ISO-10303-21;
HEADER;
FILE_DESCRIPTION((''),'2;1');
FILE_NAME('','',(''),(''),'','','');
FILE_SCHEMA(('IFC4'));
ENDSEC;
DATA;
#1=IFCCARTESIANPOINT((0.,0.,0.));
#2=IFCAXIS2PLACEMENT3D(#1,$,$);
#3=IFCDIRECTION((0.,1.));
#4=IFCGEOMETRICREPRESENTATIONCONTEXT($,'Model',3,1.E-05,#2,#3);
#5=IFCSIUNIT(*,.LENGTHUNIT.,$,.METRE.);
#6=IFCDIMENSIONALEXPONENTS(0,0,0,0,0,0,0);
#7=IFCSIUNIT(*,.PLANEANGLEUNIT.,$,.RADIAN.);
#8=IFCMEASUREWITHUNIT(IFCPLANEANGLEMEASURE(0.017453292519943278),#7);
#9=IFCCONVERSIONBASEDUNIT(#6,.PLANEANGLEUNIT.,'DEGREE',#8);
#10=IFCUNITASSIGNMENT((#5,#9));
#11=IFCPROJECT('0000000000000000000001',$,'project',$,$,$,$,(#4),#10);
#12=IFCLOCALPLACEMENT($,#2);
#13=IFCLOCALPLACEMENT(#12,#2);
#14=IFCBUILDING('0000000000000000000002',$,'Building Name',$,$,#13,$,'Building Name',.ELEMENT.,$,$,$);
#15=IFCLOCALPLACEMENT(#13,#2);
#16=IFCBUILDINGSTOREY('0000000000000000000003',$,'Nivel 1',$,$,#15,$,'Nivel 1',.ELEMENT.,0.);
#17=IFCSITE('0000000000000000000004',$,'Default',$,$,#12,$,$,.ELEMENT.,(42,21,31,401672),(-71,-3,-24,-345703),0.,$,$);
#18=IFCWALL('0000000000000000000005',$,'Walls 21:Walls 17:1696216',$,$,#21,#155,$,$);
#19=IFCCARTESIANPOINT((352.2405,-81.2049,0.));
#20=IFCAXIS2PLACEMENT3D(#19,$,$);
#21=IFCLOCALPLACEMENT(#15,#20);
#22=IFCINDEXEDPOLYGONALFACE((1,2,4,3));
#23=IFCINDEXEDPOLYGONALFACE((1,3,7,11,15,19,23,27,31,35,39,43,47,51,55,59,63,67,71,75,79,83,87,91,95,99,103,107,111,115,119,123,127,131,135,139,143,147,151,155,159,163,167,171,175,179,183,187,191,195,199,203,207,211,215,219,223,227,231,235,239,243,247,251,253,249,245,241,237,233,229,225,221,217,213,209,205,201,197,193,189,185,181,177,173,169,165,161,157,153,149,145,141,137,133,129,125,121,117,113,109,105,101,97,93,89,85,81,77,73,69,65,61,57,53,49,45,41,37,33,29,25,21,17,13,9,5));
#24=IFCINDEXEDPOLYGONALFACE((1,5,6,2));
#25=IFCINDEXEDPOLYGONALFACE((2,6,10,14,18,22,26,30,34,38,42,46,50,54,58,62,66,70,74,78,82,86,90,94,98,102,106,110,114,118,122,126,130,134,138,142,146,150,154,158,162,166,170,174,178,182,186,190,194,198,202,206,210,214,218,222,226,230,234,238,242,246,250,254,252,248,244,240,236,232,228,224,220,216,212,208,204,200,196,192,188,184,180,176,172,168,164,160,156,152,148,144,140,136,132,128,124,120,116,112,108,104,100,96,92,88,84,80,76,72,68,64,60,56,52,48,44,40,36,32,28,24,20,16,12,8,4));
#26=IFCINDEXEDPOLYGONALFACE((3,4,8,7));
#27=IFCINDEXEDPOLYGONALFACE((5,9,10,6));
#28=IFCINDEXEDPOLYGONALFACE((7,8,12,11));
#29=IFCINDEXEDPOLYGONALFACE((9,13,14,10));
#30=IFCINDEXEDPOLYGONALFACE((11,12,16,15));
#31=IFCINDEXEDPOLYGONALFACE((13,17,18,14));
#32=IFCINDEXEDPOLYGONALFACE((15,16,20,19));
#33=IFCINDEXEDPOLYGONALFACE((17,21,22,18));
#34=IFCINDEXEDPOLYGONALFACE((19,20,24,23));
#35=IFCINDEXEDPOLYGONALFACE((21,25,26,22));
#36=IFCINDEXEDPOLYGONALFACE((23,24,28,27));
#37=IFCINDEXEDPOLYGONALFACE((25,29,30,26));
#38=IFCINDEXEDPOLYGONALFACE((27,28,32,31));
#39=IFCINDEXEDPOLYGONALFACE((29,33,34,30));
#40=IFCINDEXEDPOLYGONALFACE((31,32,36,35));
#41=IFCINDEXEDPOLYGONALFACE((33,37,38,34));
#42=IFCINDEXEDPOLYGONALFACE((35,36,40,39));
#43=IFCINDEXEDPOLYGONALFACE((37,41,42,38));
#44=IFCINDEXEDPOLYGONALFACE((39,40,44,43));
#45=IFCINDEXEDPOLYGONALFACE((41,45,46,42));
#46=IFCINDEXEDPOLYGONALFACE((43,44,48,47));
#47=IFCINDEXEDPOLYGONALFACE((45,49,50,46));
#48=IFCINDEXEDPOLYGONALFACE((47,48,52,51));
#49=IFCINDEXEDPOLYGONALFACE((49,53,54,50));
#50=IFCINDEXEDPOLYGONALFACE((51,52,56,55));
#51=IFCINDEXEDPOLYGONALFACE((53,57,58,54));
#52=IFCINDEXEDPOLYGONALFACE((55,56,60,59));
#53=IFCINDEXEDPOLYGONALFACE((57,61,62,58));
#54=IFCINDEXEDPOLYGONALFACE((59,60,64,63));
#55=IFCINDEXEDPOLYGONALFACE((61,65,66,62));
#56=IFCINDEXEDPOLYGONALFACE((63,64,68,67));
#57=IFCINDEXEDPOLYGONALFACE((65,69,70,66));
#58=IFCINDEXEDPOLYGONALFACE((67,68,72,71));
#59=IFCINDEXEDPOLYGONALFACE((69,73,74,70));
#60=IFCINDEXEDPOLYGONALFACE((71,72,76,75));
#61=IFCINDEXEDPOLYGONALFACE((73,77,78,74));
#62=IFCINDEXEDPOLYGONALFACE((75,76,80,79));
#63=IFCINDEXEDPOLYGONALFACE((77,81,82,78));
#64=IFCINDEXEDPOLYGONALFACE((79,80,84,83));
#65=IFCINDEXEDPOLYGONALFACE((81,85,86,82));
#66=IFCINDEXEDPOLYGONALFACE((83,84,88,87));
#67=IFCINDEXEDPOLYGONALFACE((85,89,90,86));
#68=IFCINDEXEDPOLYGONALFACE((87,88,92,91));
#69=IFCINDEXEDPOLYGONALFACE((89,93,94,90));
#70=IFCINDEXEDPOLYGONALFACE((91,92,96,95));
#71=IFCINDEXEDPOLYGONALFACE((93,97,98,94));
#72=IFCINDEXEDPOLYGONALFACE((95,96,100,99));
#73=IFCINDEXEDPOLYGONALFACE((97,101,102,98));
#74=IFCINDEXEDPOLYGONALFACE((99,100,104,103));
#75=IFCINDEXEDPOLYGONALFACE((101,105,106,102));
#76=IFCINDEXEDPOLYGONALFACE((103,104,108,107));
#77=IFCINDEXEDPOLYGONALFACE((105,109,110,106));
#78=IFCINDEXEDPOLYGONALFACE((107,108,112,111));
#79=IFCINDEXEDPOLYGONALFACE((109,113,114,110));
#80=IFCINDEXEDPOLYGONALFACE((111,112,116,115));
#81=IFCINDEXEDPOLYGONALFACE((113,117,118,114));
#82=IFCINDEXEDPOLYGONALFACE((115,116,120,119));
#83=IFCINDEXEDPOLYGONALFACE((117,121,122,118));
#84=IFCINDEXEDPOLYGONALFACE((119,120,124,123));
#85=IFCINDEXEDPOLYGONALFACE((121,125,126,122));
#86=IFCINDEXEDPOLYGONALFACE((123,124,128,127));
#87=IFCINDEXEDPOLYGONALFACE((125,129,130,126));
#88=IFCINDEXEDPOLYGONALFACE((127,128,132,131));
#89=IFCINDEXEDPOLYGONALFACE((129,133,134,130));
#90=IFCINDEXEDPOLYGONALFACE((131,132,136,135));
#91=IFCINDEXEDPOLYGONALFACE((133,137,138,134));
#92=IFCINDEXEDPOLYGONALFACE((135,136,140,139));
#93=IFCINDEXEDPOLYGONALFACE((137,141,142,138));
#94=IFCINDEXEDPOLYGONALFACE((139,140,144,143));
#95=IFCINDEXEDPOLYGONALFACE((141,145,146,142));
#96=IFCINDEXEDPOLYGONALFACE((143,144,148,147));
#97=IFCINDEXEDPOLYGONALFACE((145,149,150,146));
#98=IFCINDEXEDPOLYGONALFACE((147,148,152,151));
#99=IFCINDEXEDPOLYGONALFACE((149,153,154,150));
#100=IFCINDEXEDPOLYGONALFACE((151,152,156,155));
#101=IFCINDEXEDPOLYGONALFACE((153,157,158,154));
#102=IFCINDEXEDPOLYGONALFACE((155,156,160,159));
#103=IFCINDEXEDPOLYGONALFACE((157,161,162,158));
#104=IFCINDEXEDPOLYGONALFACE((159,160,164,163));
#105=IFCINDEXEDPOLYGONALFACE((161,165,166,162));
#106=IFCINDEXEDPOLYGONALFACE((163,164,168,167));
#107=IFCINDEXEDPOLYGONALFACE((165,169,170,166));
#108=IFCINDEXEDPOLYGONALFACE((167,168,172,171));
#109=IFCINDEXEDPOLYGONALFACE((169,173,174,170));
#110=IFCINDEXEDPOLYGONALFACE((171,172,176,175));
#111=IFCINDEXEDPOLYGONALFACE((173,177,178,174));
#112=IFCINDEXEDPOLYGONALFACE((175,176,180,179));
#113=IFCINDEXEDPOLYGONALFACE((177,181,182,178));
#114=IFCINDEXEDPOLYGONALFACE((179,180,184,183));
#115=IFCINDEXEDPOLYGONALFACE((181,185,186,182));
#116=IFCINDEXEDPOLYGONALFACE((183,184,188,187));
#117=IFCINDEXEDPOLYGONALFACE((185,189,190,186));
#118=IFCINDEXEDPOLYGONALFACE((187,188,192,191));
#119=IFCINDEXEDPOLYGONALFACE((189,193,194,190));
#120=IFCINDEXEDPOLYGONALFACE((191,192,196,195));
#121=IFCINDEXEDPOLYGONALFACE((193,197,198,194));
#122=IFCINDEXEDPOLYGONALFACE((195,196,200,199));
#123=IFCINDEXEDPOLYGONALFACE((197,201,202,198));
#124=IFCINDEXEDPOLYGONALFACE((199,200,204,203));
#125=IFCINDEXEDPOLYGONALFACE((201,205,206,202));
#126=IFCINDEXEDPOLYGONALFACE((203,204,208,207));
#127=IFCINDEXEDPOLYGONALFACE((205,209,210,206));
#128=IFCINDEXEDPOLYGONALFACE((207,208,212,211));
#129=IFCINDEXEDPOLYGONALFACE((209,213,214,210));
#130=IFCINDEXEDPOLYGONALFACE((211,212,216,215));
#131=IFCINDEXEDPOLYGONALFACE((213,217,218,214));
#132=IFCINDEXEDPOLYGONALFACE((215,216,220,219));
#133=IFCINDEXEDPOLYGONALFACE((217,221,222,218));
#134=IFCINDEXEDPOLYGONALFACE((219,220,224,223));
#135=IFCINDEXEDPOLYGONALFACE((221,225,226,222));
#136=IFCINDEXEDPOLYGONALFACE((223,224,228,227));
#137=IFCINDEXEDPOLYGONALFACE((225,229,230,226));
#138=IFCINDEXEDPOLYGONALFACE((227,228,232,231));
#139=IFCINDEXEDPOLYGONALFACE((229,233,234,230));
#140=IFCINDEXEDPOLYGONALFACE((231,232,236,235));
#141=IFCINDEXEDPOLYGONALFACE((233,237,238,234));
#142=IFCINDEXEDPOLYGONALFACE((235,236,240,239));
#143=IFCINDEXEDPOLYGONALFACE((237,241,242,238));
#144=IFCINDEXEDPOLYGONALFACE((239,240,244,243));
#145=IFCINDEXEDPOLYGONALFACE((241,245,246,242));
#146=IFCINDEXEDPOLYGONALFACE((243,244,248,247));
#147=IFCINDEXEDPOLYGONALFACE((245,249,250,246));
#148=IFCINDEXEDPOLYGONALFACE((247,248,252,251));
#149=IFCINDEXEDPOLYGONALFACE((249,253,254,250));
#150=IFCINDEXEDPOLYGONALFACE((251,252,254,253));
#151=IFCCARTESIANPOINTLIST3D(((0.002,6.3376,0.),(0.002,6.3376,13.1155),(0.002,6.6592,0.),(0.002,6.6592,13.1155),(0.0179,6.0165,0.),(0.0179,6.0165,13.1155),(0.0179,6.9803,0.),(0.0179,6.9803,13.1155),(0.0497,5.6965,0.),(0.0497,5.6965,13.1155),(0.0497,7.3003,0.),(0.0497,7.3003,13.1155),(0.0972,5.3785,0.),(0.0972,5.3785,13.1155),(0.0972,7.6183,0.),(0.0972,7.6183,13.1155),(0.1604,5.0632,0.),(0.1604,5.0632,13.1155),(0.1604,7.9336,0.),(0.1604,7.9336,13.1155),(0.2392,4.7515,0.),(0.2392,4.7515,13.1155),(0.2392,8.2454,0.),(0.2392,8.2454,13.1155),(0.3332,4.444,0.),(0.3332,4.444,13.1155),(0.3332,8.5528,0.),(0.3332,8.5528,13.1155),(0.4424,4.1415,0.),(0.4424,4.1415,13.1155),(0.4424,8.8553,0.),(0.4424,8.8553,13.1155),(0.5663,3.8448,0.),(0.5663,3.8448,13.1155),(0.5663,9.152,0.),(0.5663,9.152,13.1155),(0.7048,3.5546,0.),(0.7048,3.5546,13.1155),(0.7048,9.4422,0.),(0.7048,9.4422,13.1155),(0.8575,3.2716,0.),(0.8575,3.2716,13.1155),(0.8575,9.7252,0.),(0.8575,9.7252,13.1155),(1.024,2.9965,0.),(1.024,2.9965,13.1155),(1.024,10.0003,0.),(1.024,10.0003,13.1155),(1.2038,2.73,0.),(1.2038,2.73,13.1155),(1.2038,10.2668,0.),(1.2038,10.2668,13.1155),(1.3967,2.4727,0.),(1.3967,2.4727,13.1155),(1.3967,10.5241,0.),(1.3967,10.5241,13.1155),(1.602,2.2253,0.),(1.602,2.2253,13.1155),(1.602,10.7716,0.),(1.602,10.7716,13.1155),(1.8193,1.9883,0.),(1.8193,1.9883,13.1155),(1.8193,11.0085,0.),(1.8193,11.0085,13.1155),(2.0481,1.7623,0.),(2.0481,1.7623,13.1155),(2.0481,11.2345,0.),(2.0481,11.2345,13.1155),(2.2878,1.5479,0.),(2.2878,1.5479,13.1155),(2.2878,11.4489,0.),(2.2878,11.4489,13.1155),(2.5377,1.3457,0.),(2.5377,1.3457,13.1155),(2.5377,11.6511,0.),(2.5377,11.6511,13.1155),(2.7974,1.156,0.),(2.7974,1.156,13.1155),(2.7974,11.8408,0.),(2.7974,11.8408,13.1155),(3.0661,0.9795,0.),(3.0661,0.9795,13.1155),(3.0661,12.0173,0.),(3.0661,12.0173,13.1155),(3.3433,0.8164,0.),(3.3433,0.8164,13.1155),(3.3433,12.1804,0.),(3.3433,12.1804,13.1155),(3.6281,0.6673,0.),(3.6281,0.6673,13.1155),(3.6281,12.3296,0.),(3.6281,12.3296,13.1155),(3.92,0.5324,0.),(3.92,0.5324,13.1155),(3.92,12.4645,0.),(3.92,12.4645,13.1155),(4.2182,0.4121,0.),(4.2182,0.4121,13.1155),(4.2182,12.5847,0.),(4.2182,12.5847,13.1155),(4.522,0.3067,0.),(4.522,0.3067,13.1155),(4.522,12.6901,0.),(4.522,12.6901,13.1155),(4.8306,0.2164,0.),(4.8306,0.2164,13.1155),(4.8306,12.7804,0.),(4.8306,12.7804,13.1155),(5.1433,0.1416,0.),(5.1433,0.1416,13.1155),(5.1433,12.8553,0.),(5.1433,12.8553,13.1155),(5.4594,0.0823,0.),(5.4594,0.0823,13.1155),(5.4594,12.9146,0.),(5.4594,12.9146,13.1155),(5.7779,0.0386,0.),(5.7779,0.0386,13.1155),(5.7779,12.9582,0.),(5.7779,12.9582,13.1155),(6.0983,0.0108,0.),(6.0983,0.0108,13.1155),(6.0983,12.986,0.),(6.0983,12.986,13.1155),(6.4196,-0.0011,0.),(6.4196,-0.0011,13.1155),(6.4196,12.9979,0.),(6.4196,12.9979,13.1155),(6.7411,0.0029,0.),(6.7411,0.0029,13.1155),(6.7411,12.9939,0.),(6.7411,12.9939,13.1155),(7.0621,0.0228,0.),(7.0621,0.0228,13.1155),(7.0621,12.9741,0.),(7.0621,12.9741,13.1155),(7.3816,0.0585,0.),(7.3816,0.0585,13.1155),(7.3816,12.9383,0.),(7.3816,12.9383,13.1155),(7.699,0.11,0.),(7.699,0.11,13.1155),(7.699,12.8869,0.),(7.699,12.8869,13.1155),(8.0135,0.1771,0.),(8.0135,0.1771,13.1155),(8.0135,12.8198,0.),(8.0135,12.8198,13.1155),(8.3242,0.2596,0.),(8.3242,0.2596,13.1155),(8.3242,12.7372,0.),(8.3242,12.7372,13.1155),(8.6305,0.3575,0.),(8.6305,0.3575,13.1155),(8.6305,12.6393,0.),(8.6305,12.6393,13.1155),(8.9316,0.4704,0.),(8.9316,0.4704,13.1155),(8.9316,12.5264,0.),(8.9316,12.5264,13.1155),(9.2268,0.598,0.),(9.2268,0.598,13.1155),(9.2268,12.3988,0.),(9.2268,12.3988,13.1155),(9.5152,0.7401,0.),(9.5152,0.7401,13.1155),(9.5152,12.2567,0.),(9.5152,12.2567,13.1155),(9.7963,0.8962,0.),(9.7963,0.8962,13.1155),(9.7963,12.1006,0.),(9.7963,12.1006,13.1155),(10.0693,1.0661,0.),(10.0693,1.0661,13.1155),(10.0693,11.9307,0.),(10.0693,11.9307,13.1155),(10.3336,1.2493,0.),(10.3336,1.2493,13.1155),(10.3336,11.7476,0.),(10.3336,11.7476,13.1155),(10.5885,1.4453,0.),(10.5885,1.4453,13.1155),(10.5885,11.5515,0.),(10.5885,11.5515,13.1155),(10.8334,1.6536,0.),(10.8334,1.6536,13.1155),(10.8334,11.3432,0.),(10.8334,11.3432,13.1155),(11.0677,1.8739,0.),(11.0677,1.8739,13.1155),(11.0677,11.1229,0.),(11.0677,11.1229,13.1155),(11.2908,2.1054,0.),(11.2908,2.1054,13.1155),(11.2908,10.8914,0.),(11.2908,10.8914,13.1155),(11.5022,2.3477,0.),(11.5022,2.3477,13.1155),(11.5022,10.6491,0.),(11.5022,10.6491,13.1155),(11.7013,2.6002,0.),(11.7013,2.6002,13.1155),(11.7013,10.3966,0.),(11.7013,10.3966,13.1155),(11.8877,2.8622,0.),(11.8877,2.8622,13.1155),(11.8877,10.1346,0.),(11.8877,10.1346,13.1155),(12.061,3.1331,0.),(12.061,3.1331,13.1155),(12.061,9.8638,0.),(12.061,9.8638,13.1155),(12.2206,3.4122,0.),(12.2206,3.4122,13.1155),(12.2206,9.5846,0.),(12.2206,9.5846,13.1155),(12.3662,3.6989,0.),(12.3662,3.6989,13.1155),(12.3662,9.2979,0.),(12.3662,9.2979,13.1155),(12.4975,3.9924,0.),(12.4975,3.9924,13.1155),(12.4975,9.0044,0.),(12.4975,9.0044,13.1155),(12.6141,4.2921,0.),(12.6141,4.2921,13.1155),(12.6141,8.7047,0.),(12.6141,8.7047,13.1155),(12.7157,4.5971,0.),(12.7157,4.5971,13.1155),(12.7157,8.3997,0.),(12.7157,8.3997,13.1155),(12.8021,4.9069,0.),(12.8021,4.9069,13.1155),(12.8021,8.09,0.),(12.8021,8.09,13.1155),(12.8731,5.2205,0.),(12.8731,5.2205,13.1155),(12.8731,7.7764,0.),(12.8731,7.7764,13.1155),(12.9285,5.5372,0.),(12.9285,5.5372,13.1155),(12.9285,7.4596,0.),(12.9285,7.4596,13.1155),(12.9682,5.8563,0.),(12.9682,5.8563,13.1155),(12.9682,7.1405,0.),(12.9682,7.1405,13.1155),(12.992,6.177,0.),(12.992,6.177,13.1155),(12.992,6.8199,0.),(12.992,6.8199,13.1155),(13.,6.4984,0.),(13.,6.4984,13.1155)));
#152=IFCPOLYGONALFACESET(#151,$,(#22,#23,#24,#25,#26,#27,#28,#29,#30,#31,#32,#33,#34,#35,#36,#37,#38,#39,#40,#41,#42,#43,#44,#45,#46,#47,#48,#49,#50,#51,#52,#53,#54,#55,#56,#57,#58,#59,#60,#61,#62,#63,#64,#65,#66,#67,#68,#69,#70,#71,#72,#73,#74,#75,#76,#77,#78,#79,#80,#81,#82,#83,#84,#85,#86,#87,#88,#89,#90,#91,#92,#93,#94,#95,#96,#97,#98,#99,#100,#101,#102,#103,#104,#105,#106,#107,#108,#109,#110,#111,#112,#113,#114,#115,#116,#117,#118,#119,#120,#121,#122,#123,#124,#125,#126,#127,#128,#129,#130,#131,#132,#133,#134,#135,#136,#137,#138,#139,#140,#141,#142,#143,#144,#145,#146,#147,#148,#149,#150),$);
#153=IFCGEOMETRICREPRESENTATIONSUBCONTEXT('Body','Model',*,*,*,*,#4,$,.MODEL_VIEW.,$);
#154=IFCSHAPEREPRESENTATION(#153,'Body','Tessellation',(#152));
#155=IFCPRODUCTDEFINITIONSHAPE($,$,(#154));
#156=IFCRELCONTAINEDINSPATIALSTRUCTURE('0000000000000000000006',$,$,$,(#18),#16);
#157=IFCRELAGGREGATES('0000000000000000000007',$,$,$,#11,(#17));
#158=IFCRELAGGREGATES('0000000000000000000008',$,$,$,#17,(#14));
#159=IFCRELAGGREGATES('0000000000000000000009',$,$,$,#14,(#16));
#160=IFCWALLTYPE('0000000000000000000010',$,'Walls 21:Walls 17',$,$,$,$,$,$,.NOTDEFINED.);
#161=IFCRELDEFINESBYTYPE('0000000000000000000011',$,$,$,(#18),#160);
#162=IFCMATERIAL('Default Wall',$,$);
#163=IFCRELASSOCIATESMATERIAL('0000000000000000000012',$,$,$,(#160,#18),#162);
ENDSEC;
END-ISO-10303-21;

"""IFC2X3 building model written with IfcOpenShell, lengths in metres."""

from ifc_helpers import new_model, entity, si_unit, converted_unit, direction, frame, frame_2d, origin, place, context, subcontext, project, spatial, circle, extrude, material, type_object, element, save


model = new_model("IFC2X3")

# Units and contexts
model_context = context("Model", 3, precision=1e-05, world=origin(), true_north=direction((0.0, 1.0)))
body_context = subcontext(model_context, "Body", "Model", "MODEL_VIEW")
ifc_project = project(units=[si_unit("LENGTHUNIT", "METRE"), converted_unit("PLANEANGLEUNIT", "DEGREE", entity("IfcPlaneAngleMeasure", 0.017453292519943278), si_unit("PLANEANGLEUNIT", "RADIAN"), dimensions=[0, 0, 0, 0, 0, 0, 0])], contexts=[model_context])

# Site, building, storey
site_placement = place(None, origin())
site = spatial("IfcSite", under=ifc_project, at=site_placement, Name="Default", CompositionType="ELEMENT", RefLatitude=(42, 21, 31, 401672), RefLongitude=(-71, -3, -24, -345703), RefElevation=0.0)
building_placement = place(site_placement, origin())
building = spatial("IfcBuilding", under=site, at=building_placement, Name="Building Name", LongName="Building Name", CompositionType="ELEMENT")
storey_placement = place(building_placement, origin())
storey = spatial("IfcBuildingStorey", under=building, at=storey_placement, Name="Nivel 1", LongName="Nivel 1", CompositionType="ELEMENT", Elevation=0.0)

# Wall
ifc_material_1 = material(Name="Default Wall")
wall_type_1 = type_object("IfcWallType", Name="Walls 21:Walls 17", PredefinedType="NOTDEFINED", material=ifc_material_1)
wall_1_placement = place(storey_placement, frame((352.2405, -81.2049, 0.0)))
element("IfcWall", 1, at=wall_1_placement, inside=storey, type_object=wall_type_1, material=ifc_material_1, Name="Walls 21:Walls 17:1696216", context=body_context, shape_type="SweptSolid", body=[
    extrude(circle(Radius=6.5, at=frame_2d((0.0, 0.0), x_axis=(1.0, 0.0))), frame((6.5, 6.4984, 0.0)), (0.0, 0.0, 1.0), 13.1155),
])

save(model, "model.ifc")
